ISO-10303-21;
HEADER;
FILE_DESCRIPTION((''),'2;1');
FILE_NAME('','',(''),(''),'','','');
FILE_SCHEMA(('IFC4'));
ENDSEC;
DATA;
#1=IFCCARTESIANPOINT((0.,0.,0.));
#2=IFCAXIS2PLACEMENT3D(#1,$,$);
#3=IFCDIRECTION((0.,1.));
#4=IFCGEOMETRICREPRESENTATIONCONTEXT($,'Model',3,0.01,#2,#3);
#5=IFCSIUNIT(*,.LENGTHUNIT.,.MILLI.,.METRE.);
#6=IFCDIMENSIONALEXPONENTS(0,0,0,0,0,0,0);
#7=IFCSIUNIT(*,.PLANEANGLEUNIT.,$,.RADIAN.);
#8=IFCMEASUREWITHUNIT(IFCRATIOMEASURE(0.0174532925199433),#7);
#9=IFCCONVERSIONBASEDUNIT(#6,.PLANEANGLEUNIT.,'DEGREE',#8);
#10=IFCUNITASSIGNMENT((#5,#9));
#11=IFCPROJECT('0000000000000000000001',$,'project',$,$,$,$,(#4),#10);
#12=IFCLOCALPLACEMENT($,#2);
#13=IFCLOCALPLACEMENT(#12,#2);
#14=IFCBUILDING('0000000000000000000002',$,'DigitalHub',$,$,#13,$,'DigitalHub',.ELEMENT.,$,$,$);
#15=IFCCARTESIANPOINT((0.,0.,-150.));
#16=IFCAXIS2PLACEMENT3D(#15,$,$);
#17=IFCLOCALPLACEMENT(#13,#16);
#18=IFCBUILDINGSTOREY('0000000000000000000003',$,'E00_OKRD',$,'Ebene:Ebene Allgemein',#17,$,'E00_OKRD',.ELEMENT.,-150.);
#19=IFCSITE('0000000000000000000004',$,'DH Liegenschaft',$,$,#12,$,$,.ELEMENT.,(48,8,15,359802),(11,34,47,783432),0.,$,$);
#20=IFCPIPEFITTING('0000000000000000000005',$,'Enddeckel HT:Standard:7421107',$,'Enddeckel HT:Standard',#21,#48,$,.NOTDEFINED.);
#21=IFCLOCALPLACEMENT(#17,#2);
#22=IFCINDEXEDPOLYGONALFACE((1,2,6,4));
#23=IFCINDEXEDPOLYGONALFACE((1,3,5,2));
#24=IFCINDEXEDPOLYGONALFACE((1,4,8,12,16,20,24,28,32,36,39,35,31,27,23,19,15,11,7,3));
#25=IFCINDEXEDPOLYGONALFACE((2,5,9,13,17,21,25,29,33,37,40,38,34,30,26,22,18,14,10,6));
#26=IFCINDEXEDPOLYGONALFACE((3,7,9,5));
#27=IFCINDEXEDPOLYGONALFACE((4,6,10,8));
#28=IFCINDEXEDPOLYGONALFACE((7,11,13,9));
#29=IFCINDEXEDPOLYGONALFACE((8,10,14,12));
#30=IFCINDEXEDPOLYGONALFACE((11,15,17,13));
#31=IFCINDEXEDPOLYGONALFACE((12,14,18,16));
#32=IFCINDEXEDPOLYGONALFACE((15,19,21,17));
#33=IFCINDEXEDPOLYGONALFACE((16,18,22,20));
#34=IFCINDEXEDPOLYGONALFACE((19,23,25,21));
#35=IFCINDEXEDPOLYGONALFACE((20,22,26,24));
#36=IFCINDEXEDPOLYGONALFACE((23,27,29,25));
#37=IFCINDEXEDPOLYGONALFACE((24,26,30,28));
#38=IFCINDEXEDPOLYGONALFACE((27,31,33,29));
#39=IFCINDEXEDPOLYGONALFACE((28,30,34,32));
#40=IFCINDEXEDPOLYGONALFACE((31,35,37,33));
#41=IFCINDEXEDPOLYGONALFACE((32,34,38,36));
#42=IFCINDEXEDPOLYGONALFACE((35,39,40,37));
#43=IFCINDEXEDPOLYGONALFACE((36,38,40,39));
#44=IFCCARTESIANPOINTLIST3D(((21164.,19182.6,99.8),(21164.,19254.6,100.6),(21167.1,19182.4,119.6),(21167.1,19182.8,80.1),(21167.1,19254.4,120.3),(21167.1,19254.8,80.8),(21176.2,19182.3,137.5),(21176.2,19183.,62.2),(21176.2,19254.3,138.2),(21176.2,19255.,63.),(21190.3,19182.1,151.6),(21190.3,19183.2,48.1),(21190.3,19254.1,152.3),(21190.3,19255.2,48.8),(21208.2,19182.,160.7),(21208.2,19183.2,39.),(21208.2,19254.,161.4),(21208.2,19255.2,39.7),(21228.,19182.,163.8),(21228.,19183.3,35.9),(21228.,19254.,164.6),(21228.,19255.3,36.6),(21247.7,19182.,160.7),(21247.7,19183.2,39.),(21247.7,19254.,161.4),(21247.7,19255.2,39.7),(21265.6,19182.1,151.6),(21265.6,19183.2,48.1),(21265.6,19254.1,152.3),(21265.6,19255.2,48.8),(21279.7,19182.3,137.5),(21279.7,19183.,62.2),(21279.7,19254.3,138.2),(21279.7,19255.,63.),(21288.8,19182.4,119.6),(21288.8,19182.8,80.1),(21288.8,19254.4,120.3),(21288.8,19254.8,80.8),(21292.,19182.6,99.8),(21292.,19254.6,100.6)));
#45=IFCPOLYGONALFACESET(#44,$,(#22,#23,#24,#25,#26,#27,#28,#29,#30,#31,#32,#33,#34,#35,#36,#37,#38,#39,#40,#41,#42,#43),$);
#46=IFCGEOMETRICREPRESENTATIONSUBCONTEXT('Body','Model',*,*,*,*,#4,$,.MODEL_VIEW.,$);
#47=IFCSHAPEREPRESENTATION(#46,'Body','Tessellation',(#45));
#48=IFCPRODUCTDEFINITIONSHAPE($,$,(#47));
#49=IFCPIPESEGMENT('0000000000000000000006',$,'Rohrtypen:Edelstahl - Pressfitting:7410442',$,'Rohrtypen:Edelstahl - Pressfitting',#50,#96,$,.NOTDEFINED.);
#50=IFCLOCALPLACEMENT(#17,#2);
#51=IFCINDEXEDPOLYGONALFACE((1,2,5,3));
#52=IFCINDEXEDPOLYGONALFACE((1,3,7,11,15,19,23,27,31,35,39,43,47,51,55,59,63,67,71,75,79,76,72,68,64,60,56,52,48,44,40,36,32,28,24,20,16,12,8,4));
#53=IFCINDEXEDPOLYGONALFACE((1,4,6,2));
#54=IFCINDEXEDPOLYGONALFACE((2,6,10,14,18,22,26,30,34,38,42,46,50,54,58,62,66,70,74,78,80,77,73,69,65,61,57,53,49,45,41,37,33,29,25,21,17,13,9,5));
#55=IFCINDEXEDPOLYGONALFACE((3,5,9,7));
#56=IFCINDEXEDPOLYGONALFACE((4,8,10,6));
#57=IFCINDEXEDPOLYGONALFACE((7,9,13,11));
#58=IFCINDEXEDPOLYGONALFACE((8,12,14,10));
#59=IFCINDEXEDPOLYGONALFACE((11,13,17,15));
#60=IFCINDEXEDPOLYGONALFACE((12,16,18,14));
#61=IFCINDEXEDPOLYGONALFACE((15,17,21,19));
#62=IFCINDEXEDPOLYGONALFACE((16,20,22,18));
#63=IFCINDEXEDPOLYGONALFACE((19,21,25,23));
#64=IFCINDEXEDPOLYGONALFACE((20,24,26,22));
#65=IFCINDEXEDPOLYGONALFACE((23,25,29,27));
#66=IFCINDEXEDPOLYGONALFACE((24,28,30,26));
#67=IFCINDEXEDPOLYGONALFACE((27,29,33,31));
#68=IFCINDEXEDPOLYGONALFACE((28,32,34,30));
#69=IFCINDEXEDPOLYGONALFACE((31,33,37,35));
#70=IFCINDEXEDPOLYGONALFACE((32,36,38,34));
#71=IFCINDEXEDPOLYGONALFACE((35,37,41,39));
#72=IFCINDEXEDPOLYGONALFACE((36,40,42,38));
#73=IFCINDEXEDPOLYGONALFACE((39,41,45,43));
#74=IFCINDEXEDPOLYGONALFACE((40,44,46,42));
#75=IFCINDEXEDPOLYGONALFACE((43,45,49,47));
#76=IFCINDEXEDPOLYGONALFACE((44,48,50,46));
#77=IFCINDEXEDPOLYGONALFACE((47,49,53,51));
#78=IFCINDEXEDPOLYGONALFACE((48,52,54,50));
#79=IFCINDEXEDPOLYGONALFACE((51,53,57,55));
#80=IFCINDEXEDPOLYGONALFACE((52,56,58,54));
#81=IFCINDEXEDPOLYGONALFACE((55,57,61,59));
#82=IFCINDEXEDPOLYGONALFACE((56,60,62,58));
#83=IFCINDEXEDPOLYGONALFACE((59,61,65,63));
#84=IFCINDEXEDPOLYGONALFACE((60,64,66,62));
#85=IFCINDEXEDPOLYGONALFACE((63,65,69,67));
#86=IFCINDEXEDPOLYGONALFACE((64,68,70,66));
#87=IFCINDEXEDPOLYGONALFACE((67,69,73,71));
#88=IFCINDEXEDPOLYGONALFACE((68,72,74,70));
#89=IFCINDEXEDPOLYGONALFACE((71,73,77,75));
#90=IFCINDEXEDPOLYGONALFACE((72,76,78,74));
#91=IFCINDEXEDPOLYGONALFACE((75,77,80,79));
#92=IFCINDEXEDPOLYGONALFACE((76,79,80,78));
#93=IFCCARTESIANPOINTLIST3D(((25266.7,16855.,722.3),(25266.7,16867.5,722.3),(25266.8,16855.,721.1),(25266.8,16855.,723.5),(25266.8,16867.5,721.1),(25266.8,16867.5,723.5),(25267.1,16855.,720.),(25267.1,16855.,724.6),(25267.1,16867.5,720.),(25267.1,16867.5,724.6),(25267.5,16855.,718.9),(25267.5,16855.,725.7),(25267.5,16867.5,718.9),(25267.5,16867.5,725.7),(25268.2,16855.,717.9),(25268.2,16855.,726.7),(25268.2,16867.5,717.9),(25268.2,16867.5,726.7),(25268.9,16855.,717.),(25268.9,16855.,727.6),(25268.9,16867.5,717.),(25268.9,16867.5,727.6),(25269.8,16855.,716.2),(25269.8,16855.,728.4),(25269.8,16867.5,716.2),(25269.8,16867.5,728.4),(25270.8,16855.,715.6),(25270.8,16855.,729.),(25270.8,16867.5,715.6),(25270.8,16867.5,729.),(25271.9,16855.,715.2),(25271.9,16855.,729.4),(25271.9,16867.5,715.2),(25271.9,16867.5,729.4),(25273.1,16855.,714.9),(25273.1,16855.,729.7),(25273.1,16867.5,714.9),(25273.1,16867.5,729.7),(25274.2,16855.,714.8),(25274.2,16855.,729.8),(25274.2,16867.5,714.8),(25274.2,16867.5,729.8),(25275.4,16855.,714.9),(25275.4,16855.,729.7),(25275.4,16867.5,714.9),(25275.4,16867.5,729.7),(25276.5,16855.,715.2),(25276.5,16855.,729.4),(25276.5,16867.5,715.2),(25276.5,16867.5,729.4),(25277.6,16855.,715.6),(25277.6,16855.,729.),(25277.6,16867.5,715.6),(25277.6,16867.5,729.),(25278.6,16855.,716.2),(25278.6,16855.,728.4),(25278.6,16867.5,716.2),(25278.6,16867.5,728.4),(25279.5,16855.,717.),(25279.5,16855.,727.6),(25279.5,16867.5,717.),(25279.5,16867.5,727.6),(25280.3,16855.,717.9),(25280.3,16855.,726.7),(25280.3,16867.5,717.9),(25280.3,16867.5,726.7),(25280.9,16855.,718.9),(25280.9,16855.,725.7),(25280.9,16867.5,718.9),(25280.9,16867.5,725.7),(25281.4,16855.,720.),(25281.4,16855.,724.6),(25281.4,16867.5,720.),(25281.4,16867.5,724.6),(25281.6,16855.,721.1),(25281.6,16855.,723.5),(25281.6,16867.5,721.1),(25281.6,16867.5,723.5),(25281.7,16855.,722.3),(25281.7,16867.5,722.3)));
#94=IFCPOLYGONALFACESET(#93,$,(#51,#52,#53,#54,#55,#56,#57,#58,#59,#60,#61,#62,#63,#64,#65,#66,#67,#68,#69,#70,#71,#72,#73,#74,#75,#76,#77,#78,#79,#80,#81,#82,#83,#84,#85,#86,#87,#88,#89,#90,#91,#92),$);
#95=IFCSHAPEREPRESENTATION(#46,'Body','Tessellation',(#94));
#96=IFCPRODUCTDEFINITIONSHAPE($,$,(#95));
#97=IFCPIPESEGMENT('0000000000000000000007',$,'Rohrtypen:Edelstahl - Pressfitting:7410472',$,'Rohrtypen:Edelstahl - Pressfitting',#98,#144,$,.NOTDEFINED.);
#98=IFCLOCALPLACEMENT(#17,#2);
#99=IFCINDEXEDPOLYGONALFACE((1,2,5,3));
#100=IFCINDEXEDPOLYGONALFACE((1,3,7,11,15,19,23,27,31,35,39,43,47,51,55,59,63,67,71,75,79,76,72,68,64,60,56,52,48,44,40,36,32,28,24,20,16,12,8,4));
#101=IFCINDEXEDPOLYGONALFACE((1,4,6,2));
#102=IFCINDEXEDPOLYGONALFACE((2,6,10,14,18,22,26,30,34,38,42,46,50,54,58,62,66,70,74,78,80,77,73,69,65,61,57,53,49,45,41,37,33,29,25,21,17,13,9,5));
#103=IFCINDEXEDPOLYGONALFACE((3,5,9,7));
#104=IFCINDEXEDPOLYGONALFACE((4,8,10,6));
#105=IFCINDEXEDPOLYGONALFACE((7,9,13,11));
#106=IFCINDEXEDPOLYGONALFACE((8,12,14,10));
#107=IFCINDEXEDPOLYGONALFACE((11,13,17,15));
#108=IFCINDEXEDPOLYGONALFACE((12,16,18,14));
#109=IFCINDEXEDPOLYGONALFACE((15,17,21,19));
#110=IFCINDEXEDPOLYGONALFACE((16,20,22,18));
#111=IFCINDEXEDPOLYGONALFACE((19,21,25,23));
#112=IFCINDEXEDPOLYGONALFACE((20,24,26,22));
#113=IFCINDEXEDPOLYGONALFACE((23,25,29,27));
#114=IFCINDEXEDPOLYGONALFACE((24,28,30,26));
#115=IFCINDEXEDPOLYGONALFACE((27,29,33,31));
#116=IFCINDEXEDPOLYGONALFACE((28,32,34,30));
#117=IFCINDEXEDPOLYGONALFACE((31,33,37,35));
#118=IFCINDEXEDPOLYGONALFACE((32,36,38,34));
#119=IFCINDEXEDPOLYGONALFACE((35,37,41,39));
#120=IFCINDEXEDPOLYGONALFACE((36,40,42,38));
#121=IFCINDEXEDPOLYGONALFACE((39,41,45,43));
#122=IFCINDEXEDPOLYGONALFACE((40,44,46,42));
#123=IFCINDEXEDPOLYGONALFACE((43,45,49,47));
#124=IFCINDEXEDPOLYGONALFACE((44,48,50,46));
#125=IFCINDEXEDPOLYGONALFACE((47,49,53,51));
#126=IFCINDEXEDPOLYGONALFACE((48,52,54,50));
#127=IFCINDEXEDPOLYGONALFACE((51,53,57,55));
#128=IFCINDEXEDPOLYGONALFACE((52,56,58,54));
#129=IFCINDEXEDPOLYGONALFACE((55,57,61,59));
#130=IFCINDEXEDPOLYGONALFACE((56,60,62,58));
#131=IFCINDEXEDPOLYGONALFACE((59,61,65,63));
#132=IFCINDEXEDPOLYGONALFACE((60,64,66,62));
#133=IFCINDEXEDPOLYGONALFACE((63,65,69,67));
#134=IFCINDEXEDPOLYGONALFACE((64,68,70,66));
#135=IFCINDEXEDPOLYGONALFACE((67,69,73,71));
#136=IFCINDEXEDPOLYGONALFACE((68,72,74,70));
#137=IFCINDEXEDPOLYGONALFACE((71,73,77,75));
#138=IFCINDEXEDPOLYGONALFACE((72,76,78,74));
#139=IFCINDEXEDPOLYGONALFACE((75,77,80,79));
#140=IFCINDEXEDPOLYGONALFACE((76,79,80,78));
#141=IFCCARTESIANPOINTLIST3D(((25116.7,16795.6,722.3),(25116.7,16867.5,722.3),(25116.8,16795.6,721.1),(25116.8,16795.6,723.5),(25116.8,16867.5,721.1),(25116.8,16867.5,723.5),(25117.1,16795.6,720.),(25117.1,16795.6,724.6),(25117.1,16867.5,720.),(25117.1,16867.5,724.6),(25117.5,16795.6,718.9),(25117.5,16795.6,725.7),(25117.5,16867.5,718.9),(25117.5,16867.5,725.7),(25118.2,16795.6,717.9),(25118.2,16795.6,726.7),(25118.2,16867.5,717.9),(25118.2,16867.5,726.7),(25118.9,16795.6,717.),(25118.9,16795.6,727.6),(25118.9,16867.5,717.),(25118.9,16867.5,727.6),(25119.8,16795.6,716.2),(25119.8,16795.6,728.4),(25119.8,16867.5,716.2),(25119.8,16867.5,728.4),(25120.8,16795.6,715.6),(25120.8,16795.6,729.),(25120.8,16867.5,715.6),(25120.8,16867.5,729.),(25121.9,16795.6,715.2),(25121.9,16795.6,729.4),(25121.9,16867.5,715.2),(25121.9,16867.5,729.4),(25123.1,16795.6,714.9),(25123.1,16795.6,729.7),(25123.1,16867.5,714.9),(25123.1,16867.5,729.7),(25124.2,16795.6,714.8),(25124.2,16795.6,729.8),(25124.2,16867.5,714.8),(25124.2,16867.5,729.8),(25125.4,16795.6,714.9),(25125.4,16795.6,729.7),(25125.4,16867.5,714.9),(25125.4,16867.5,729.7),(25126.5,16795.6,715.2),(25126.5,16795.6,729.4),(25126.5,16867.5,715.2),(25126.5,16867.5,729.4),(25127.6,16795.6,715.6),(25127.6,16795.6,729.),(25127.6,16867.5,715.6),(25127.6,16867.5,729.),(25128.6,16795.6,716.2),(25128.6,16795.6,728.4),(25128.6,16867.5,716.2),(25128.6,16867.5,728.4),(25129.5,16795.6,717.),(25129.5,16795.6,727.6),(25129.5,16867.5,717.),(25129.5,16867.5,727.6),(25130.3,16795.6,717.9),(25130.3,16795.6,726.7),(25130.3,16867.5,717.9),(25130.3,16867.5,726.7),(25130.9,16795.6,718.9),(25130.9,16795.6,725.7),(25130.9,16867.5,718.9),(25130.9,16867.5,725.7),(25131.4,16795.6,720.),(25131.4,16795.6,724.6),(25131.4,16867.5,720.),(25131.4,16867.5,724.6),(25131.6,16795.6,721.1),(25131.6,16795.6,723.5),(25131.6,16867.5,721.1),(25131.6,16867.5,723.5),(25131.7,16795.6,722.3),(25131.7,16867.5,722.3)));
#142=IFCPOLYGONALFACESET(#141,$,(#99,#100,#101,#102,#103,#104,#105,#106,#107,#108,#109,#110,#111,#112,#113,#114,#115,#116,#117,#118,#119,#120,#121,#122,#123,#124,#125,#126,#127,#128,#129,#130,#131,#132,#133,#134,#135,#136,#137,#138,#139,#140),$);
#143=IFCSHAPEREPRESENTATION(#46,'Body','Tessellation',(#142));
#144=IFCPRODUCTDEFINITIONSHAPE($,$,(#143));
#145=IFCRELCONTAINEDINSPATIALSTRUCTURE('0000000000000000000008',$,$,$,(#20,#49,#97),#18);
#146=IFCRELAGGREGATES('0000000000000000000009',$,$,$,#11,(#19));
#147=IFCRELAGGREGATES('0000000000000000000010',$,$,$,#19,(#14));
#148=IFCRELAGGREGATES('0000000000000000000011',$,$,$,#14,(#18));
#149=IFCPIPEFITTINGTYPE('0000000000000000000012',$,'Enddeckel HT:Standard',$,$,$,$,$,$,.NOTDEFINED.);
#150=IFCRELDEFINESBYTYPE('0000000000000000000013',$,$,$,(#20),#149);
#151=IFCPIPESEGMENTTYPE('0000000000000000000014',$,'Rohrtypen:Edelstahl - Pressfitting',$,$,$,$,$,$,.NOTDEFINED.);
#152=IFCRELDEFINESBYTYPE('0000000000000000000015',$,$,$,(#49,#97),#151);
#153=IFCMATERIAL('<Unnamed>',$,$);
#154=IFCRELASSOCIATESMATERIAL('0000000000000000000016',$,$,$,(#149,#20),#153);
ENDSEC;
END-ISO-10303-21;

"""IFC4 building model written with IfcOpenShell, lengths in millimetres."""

from ifc_helpers import new_model, entity, si_unit, converted_unit, direction, frame, origin, place, context, subcontext, project, spatial, indexed_curve, outline, extrude, source, transform, mapped, material, type_object, type_shapes, element, save


model = new_model("IFC4")

# Units and contexts
model_context = context("Model", 3, precision=0.01, world=origin(), true_north=direction((0.0, 1.0)))
body_context = subcontext(model_context, "Body", "Model", "MODEL_VIEW")
ifc_project = project(units=[si_unit("LENGTHUNIT", "METRE", prefix="MILLI"), converted_unit("PLANEANGLEUNIT", "DEGREE", entity("IfcRatioMeasure", 0.0174532925199433), si_unit("PLANEANGLEUNIT", "RADIAN"), dimensions=[0, 0, 0, 0, 0, 0, 0])], contexts=[model_context])

# Site, building, storey
site_placement = place(None, origin())
site = spatial("IfcSite", under=ifc_project, at=site_placement, Name="DH Liegenschaft", CompositionType="ELEMENT", RefLatitude=(48, 8, 15, 359802), RefLongitude=(11, 34, 47, 783432), RefElevation=0.0)
building_placement = place(site_placement, origin())
building = spatial("IfcBuilding", under=site, at=building_placement, Name="DigitalHub", LongName="DigitalHub", CompositionType="ELEMENT")
storey_placement = place(building_placement, frame((0.0, 0.0, -150.0)))
storey = spatial("IfcBuildingStorey", under=building, at=storey_placement, Name="E00_OKRD", ObjectType="Ebene:Ebene Allgemein", LongName="E00_OKRD", CompositionType="ELEMENT", Elevation=-150.0)

# Pipe fitting
ifc_material = material(Name="<Unnamed>")
pipe_fitting_type = type_object("IfcPipeFittingType", Name="Enddeckel HT:Standard", PredefinedType="NOTDEFINED", material=ifc_material)
shared_shape = source(origin(), body_context, "Body", "SweptSolid", [
    extrude(outline(indexed_curve([(64.0, 0.0), (60.9, 19.8), (51.8, 37.6), (37.6, 51.8), (19.8, 60.9), (0.0, 64.0), (-19.8, 60.9), (-37.6, 51.8), (-51.8, 37.6), (-60.9, 19.8), (-64.0, 0.0), (-60.9, -19.8), (-51.8, -37.6), (-37.6, -51.8), (-19.8, -60.9), (0.0, -64.0), (19.8, -60.9), (37.6, -51.8), (51.8, -37.6), (60.9, -19.8), (64.0, 0.0)], self_intersect=False)), frame((0.0, 0.0, 0.0), z_axis=(1.0, 0.0, 0.0), x_axis=(0.0, 1.0, 0.0)), (0.0, 0.0, 1.0), 72.0),
])
type_shapes(pipe_fitting_type, [shared_shape])
pipe_fitting_placement = place(storey_placement, frame((21228.0, 19182.6, 99.8), z_axis=(0.0, -0.01, 0.99995), x_axis=(0.0, 0.99995, 0.01)))
element("IfcPipeFitting", 1, at=pipe_fitting_placement, inside=storey, type_object=pipe_fitting_type, material=ifc_material, Name="Enddeckel HT:Standard:7421107", ObjectType="Enddeckel HT:Standard", PredefinedType="NOTDEFINED", context=body_context, shape_type="MappedRepresentation", body=[
    mapped(shared_shape, transform((0.0, 0.0, 0.0), scale=1.0)),
])

# Pipe segments
pipe_segment_type_1 = type_object("IfcPipeSegmentType", Name="Rohrtypen:Edelstahl - Pressfitting", PredefinedType="NOTDEFINED")
pipe_segment_1_placement = place(storey_placement, frame((25265.1, 16855.0, 713.2)))
element("IfcPipeSegment", 2, at=pipe_segment_1_placement, inside=storey, type_object=pipe_segment_type_1, Name="Rohrtypen:Edelstahl - Pressfitting:7410442", ObjectType="Rohrtypen:Edelstahl - Pressfitting", PredefinedType="NOTDEFINED", context=body_context, shape_type="SweptSolid", body=[
    extrude(outline(indexed_curve([(7.5, 0.0), (7.4, 1.2), (7.1, 2.3), (6.7, 3.4), (6.1, 4.4), (5.3, 5.3), (4.4, 6.1), (3.4, 6.7), (2.3, 7.1), (1.2, 7.4), (0.0, 7.5), (-1.2, 7.4), (-2.3, 7.1), (-3.4, 6.7), (-4.4, 6.1), (-5.3, 5.3), (-6.1, 4.4), (-6.7, 3.4), (-7.1, 2.3), (-7.4, 1.2), (-7.5, 0.0), (-7.4, -1.2), (-7.1, -2.3), (-6.7, -3.4), (-6.1, -4.4), (-5.3, -5.3), (-4.4, -6.1), (-3.4, -6.7), (-2.3, -7.1), (-1.2, -7.4), (0.0, -7.5), (1.2, -7.4), (2.3, -7.1), (3.4, -6.7), (4.4, -6.1), (5.3, -5.3), (6.1, -4.4), (6.7, -3.4), (7.1, -2.3), (7.4, -1.2), (7.5, 0.0)], self_intersect=False)), frame((9.1, 0.0, 9.1), z_axis=(0.0, 1.0, 0.0), x_axis=(-1.0, 0.0, 0.0)), (0.0, 0.0, 1.0), 12.6),
])
pipe_segment_2_placement = place(storey_placement, frame((25115.1, 16795.6, 713.2)))
element("IfcPipeSegment", 3, at=pipe_segment_2_placement, inside=storey, type_object=pipe_segment_type_1, Name="Rohrtypen:Edelstahl - Pressfitting:7410472", ObjectType="Rohrtypen:Edelstahl - Pressfitting", PredefinedType="NOTDEFINED", context=body_context, shape_type="SweptSolid", body=[
    extrude(outline(indexed_curve([(7.5, 0.0), (7.4, 1.2), (7.1, 2.3), (6.7, 3.4), (6.1, 4.4), (5.3, 5.3), (4.4, 6.1), (3.4, 6.7), (2.3, 7.1), (1.2, 7.4), (0.0, 7.5), (-1.2, 7.4), (-2.3, 7.1), (-3.4, 6.7), (-4.4, 6.1), (-5.3, 5.3), (-6.1, 4.4), (-6.7, 3.4), (-7.1, 2.3), (-7.4, 1.2), (-7.5, 0.0), (-7.4, -1.2), (-7.1, -2.3), (-6.7, -3.4), (-6.1, -4.4), (-5.3, -5.3), (-4.4, -6.1), (-3.4, -6.7), (-2.3, -7.1), (-1.2, -7.4), (0.0, -7.5), (1.2, -7.4), (2.3, -7.1), (3.4, -6.7), (4.4, -6.1), (5.3, -5.3), (6.1, -4.4), (6.7, -3.4), (7.1, -2.3), (7.4, -1.2), (7.5, 0.0)], self_intersect=False)), frame((9.1, 0.0, 9.1), z_axis=(0.0, 1.0, 0.0), x_axis=(-1.0, 0.0, 0.0)), (0.0, 0.0, 1.0), 71.9),
])

save(model, "model.ifc")
